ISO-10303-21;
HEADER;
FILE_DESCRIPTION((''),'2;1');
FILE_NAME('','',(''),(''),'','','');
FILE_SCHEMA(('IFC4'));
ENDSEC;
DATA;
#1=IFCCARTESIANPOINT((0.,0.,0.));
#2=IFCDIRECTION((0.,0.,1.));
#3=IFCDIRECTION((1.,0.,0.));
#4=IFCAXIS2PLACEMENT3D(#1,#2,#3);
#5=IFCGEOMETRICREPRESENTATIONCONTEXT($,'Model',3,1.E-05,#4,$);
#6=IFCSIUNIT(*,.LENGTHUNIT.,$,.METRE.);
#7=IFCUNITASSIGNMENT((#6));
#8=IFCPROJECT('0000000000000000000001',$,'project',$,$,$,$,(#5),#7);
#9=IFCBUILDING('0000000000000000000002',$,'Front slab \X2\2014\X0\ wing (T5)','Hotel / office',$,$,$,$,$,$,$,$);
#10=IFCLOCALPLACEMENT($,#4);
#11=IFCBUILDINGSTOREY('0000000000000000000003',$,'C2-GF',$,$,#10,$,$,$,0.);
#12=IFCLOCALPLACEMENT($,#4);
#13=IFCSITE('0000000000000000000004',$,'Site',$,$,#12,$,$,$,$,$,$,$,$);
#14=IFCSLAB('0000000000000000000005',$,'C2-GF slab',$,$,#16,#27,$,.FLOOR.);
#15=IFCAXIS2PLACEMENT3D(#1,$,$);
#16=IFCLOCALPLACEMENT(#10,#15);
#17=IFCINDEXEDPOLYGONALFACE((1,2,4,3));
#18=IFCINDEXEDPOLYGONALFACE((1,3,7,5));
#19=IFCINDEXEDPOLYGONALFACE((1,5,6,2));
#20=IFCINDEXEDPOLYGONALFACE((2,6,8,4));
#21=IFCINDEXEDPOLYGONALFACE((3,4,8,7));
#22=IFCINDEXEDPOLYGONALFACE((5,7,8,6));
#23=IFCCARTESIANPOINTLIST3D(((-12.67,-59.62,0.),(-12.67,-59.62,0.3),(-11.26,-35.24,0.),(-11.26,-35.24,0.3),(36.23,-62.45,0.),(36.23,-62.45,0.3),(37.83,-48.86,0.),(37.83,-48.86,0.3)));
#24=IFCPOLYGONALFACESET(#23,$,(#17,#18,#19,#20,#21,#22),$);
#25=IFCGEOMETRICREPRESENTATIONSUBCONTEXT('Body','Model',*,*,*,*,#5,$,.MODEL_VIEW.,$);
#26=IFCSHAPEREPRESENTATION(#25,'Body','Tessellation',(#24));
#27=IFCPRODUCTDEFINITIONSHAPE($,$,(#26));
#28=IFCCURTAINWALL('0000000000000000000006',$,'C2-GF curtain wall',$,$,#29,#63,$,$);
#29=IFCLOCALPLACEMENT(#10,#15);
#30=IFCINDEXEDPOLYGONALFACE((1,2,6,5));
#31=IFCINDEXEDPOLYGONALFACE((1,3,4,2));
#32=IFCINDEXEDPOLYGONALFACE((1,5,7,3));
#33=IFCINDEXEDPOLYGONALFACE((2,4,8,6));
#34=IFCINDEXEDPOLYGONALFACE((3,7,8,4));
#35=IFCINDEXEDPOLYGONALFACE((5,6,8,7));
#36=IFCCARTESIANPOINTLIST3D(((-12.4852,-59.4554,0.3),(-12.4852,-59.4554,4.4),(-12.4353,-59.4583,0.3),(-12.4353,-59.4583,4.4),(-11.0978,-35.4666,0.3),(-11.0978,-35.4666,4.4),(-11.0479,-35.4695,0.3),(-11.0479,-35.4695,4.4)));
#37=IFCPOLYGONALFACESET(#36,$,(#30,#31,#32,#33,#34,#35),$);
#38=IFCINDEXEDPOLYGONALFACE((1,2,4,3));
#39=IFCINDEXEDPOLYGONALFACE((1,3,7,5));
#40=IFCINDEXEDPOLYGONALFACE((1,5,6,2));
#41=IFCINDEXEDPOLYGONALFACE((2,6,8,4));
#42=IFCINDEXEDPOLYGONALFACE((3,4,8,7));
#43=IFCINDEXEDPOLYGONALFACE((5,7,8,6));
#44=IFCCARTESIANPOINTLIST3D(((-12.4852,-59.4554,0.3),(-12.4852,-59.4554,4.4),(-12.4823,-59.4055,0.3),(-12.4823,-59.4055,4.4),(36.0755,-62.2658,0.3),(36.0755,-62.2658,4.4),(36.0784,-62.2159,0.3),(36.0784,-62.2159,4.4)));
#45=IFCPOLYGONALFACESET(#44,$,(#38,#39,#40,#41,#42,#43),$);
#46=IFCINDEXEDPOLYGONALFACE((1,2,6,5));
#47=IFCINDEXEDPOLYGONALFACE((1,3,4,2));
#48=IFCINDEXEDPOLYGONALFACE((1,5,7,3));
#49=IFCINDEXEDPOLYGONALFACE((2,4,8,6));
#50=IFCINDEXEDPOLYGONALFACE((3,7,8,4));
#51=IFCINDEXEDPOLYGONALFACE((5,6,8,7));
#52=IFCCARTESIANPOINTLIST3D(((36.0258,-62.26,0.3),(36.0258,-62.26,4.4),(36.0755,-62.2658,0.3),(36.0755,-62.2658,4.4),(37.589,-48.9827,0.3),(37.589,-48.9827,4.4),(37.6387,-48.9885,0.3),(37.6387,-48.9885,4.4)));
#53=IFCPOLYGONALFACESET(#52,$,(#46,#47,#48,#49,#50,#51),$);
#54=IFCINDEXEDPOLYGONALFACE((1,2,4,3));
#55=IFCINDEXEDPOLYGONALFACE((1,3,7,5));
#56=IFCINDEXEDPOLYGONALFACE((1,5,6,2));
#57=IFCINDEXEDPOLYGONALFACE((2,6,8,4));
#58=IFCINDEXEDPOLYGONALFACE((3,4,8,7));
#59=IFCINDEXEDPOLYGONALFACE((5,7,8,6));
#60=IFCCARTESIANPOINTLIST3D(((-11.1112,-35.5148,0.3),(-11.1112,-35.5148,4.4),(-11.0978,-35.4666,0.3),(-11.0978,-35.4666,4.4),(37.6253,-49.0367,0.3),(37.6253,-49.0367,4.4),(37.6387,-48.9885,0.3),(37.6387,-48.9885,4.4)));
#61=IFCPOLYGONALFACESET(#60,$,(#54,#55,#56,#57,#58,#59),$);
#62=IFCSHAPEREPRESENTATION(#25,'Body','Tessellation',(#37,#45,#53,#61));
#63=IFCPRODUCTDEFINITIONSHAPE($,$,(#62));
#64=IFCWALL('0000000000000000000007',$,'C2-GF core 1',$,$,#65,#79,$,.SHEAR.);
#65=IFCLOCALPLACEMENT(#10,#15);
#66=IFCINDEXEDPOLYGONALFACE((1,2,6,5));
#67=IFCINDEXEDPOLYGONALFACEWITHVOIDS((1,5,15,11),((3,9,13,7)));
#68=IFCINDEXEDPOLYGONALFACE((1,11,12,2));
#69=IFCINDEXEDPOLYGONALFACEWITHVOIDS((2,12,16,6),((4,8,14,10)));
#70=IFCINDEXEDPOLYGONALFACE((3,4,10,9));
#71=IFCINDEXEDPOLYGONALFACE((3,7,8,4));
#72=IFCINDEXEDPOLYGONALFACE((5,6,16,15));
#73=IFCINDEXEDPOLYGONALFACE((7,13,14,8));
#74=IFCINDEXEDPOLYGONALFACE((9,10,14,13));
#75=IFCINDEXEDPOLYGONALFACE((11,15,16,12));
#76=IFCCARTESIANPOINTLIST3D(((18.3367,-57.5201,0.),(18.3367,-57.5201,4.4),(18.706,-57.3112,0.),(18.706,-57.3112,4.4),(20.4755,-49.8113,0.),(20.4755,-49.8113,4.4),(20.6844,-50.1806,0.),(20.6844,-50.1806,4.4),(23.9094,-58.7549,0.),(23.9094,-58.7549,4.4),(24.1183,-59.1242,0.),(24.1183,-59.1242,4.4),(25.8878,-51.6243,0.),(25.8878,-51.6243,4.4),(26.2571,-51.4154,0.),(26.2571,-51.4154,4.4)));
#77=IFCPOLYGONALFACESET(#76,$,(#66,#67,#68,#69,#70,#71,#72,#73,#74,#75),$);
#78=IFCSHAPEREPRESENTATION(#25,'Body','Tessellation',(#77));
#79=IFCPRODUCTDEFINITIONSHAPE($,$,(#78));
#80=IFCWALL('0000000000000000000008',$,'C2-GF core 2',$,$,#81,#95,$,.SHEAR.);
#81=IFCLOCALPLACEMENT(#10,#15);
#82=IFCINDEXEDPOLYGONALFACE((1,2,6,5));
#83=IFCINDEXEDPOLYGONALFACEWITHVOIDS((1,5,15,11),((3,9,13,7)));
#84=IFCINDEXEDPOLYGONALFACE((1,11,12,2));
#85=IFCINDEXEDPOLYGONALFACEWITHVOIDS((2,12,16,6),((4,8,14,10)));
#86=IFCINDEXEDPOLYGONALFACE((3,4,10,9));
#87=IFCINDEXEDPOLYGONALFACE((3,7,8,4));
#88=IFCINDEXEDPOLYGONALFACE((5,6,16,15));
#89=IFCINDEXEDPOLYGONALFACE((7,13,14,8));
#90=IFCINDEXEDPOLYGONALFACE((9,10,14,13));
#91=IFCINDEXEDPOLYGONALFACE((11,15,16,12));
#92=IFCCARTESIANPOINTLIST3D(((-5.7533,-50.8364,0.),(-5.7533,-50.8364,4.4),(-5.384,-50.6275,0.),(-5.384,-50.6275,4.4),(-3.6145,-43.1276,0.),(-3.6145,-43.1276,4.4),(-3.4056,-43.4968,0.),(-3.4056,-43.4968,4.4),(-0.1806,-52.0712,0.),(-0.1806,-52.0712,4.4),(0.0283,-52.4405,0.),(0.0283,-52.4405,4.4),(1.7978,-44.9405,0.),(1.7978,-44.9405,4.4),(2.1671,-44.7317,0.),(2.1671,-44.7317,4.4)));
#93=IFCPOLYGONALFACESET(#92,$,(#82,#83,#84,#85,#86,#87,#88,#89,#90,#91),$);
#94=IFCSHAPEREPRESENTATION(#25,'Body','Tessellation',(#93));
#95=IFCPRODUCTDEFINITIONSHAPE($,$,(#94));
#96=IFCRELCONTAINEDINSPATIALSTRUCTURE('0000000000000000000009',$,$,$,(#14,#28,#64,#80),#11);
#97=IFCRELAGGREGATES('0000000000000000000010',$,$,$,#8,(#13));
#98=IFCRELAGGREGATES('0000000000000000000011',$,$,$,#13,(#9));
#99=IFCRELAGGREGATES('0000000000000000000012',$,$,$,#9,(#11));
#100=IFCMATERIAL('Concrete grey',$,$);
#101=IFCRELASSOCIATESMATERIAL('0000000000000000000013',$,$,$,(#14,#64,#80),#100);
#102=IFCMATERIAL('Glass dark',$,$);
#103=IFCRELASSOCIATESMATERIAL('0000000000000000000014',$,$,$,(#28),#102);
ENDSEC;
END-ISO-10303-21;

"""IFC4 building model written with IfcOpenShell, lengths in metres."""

from ifc_helpers import new_model, si_unit, frame, origin_with_axes, place, context, subcontext, project, spatial, polyline, outline, extrude, material, element, save


model = new_model("IFC4")

# Units and contexts
model_context = context("Model", 3, precision=1e-05, world=origin_with_axes())
body_context = subcontext(model_context, "Body", "Model", "MODEL_VIEW")
ifc_project = project(units=[si_unit("LENGTHUNIT", "METRE")], contexts=[model_context])

# Site, building, storey
site_placement = place(None, origin_with_axes())
site = spatial("IfcSite", under=ifc_project, at=site_placement, Name="Site")
building = spatial("IfcBuilding", under=site, Name="Front slab — wing (T5)", Description="Hotel / office")
storey_placement = place(None, origin_with_axes())
storey = spatial("IfcBuildingStorey", under=building, at=storey_placement, Name="C2-GF", Elevation=0.0)

# Slab
ifc_material_1 = material(Name="Concrete grey")
slab_placement = place(storey_placement, origin_with_axes())
element("IfcSlab", 1, at=slab_placement, inside=storey, material=ifc_material_1, Name="C2-GF slab", PredefinedType="FLOOR", context=body_context, shape_type="SweptSolid", body=[
    extrude(outline(polyline([(-11.26, -35.24), (-12.67, -59.62), (36.23, -62.45), (37.83, -48.86), (-11.26, -35.24)])), origin_with_axes(), (0.0, 0.0, 1.0), 0.3),
])

# Curtain wall
ifc_material_2 = material(Name="Glass dark")
curtain_wall_placement = place(storey_placement, origin_with_axes())
element("IfcCurtainWall", 2, at=curtain_wall_placement, inside=storey, material=ifc_material_2, Name="C2-GF curtain wall", context=body_context, shape_type="SweptSolid", body=[
    extrude(outline(polyline([(-11.0978, -35.4666), (-12.4852, -59.4554), (-12.4353, -59.4583), (-11.0479, -35.4695), (-11.0978, -35.4666)])), frame((0.0, 0.0, 0.3), z_axis=(0.0, 0.0, 1.0), x_axis=(1.0, 0.0, 0.0)), (0.0, 0.0, 1.0), 4.1),
    extrude(outline(polyline([(-12.4852, -59.4554), (36.0755, -62.2658), (36.0784, -62.2159), (-12.4823, -59.4055), (-12.4852, -59.4554)])), frame((0.0, 0.0, 0.3), z_axis=(0.0, 0.0, 1.0), x_axis=(1.0, 0.0, 0.0)), (0.0, 0.0, 1.0), 4.1),
    extrude(outline(polyline([(36.0755, -62.2658), (37.6387, -48.9885), (37.589, -48.9827), (36.0258, -62.26), (36.0755, -62.2658)])), frame((0.0, 0.0, 0.3), z_axis=(0.0, 0.0, 1.0), x_axis=(1.0, 0.0, 0.0)), (0.0, 0.0, 1.0), 4.1),
    extrude(outline(polyline([(37.6387, -48.9885), (-11.0978, -35.4666), (-11.1112, -35.5148), (37.6253, -49.0367), (37.6387, -48.9885)])), frame((0.0, 0.0, 0.3), z_axis=(0.0, 0.0, 1.0), x_axis=(1.0, 0.0, 0.0)), (0.0, 0.0, 1.0), 4.1),
])

# Walls
wall_1_placement = place(storey_placement, origin_with_axes())
element("IfcWall", 3, at=wall_1_placement, inside=storey, material=ifc_material_1, Name="C2-GF core 1", PredefinedType="SHEAR", context=body_context, shape_type="SweptSolid", body=[
    extrude(outline(polyline([(26.2571, -51.4154), (20.4755, -49.8113), (18.3367, -57.5201), (24.1183, -59.1242), (26.2571, -51.4154)]), holes=[polyline([(25.8878, -51.6243), (20.6844, -50.1806), (18.706, -57.3112), (23.9094, -58.7549), (25.8878, -51.6243)])]), origin_with_axes(), (0.0, 0.0, 1.0), 4.4),
])
wall_2_placement = place(storey_placement, origin_with_axes())
element("IfcWall", 4, at=wall_2_placement, inside=storey, material=ifc_material_1, Name="C2-GF core 2", PredefinedType="SHEAR", context=body_context, shape_type="SweptSolid", body=[
    extrude(outline(polyline([(2.1671, -44.7317), (-3.6145, -43.1276), (-5.7533, -50.8364), (0.0283, -52.4405), (2.1671, -44.7317)]), holes=[polyline([(1.7978, -44.9405), (-3.4056, -43.4968), (-5.384, -50.6275), (-0.1806, -52.0712), (1.7978, -44.9405)])]), origin_with_axes(), (0.0, 0.0, 1.0), 4.4),
])

save(model, "model.ifc")
